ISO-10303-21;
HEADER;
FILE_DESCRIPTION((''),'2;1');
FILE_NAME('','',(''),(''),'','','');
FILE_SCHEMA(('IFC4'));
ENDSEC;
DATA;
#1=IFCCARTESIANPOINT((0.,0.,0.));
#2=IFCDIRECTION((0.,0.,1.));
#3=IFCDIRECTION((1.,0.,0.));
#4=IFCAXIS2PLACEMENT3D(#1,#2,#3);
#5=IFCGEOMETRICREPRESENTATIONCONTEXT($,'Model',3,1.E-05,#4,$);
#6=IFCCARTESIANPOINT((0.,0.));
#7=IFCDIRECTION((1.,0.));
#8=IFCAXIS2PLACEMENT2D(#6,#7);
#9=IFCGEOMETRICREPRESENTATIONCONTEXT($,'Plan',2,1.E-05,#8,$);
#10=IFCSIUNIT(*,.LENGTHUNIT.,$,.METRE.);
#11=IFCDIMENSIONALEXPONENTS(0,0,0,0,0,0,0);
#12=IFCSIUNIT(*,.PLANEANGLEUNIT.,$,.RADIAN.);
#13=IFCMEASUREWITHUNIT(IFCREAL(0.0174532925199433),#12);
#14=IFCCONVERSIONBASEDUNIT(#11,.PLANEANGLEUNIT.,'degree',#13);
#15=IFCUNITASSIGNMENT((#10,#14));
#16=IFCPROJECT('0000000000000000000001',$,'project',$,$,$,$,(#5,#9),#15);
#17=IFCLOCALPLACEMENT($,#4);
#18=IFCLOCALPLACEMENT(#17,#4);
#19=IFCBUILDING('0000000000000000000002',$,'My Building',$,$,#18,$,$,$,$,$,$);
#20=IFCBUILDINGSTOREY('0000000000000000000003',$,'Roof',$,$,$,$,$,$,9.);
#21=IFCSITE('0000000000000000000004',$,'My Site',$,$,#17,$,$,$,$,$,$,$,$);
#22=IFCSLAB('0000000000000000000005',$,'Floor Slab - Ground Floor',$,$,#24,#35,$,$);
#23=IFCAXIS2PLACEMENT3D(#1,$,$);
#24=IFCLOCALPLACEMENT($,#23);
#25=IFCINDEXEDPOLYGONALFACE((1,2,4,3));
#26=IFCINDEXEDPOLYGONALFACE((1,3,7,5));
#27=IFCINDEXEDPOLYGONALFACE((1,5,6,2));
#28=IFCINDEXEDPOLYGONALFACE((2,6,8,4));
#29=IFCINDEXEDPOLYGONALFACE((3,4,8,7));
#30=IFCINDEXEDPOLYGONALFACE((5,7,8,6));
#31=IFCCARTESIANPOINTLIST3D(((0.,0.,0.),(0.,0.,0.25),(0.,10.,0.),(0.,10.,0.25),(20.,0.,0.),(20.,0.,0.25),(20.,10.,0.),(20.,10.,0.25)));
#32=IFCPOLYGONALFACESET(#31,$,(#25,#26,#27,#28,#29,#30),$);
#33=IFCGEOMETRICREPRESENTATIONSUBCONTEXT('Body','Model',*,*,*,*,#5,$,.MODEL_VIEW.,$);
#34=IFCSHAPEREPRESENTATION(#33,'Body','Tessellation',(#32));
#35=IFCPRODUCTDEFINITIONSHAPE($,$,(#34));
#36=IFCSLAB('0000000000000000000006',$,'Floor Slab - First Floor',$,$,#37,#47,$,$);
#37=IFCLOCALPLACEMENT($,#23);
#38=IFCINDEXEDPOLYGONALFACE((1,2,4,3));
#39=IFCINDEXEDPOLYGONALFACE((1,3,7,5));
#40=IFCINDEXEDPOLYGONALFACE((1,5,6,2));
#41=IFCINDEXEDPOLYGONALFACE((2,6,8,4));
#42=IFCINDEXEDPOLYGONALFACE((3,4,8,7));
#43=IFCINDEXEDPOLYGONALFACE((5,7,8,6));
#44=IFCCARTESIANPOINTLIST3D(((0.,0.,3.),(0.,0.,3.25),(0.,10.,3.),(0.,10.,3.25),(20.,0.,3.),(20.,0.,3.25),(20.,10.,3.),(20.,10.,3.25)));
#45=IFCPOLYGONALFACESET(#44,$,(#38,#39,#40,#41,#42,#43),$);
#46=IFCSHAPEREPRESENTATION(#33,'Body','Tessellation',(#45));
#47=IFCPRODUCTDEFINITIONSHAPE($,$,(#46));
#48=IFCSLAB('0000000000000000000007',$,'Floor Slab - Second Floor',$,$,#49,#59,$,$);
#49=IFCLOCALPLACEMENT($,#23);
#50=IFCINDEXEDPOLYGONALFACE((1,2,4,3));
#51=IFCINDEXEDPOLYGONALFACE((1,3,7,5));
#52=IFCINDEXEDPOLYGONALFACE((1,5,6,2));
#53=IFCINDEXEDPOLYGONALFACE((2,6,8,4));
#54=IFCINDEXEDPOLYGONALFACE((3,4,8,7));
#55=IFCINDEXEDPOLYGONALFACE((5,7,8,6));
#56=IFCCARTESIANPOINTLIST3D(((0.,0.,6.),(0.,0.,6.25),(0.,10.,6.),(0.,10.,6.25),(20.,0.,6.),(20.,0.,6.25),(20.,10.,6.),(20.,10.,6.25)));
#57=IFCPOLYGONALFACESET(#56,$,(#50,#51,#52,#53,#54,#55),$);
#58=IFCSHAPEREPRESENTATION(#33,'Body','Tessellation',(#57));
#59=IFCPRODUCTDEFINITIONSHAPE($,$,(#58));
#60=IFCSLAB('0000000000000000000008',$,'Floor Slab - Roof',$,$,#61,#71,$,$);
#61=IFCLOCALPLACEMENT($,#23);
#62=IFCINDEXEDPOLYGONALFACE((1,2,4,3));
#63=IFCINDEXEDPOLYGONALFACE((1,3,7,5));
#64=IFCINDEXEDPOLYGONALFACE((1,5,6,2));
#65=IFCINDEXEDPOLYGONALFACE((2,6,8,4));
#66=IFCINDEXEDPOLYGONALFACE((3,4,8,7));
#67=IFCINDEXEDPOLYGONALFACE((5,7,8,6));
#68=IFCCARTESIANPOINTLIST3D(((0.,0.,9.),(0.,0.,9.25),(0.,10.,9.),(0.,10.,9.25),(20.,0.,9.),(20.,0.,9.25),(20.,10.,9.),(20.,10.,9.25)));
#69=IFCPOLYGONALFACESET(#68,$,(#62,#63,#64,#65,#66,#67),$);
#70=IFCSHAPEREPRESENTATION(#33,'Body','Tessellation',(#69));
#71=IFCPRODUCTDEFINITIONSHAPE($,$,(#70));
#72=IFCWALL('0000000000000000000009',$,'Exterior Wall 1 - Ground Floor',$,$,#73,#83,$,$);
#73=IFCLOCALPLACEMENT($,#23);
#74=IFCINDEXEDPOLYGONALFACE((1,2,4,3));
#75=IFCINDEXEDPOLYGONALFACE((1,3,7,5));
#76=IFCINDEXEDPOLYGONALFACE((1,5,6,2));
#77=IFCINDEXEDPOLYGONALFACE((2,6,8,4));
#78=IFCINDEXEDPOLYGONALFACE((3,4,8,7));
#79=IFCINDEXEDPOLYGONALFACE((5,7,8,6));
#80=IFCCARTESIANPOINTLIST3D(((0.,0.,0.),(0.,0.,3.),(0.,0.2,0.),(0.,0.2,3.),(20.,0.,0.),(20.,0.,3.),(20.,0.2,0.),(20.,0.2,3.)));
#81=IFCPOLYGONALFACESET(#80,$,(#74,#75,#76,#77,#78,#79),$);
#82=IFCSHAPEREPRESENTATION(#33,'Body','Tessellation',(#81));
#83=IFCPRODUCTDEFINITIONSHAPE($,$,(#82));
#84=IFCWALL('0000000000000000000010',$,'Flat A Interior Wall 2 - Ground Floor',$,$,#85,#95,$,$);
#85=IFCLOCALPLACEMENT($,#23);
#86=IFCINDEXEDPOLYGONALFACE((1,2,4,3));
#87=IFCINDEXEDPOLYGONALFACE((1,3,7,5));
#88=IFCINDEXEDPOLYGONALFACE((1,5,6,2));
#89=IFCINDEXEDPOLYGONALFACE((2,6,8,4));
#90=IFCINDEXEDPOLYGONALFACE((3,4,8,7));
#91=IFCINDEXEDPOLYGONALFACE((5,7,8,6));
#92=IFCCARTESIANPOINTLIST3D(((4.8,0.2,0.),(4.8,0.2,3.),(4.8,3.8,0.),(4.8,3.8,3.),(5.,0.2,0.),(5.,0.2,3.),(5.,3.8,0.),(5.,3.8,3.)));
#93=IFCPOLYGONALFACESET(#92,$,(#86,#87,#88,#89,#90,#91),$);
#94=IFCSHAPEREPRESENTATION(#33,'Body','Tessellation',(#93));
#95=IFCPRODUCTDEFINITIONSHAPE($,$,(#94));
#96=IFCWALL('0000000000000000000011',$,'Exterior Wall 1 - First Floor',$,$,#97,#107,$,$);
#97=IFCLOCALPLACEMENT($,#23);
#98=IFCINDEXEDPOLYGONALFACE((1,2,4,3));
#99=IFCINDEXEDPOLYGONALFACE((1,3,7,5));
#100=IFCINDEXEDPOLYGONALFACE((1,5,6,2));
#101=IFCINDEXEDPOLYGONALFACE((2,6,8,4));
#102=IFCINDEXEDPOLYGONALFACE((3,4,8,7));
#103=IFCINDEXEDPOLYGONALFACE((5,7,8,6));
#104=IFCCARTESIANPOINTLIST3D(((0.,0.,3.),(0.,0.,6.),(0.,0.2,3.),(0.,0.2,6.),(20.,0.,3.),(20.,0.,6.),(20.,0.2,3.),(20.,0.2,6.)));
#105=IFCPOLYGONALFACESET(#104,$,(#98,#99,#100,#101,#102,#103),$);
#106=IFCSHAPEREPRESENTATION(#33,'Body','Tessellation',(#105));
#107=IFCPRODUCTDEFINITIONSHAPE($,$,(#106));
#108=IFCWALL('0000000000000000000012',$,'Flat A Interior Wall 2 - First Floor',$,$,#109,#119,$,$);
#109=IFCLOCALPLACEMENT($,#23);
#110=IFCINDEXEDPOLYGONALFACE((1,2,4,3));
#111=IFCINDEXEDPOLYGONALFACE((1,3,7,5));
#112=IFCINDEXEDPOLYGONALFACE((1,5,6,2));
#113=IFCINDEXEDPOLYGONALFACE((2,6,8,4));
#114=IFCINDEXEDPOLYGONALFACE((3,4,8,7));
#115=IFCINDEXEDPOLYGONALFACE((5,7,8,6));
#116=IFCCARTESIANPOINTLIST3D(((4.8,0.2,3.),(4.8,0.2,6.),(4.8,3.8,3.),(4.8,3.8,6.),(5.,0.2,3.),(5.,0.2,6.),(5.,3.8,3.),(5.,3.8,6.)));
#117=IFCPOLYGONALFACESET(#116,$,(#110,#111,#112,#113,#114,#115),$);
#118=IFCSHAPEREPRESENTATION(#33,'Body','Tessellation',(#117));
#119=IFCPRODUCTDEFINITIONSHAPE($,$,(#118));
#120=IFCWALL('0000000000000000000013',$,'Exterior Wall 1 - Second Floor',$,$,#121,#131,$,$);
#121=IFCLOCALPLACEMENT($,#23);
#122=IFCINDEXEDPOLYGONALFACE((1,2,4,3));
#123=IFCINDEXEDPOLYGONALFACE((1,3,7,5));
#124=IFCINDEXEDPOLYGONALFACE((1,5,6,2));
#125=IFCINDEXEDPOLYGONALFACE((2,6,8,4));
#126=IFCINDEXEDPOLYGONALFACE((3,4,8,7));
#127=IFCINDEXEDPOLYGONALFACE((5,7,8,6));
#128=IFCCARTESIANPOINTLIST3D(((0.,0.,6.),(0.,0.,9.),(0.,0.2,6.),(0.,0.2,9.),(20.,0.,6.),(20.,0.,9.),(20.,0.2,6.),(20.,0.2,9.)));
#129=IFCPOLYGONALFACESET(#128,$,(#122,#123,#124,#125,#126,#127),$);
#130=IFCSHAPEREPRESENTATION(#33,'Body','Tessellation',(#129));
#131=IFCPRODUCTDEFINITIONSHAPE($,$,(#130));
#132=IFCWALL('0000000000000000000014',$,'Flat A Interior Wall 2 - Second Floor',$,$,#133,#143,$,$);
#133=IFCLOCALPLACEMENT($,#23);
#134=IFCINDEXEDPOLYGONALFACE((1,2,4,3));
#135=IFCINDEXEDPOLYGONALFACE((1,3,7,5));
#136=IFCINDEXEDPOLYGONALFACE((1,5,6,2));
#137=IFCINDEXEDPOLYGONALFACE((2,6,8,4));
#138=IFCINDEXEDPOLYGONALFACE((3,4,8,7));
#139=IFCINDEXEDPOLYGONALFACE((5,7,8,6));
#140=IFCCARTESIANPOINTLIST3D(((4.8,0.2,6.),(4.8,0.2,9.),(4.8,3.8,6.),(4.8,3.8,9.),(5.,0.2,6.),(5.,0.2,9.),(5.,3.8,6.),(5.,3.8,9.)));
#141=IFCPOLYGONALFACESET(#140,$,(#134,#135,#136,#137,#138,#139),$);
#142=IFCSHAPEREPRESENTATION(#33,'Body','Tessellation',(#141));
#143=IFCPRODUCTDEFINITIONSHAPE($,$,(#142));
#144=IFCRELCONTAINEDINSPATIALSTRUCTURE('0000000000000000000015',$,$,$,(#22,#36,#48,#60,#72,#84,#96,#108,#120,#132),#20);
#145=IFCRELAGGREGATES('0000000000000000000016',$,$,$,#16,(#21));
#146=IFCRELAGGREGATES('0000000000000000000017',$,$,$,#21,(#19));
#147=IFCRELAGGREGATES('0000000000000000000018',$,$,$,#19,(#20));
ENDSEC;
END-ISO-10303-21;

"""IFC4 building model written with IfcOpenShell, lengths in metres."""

from ifc_helpers import new_model, entity, si_unit, converted_unit, frame, origin_with_axes, origin_2d_with_axis, place, context, subcontext, project, spatial, indexed_curve, outline, extrude, element, save


model = new_model("IFC4")

# Units and contexts
model_context = context("Model", 3, precision=1e-05, world=origin_with_axes())
plan_context = context("Plan", 2, precision=1e-05, world=origin_2d_with_axis())
body_context = subcontext(model_context, "Body", "Model", "MODEL_VIEW")
ifc_project = project(units=[si_unit("LENGTHUNIT", "METRE"), converted_unit("PLANEANGLEUNIT", "degree", entity("IfcReal", 0.0174532925199433), si_unit("PLANEANGLEUNIT", "RADIAN"), dimensions=[0, 0, 0, 0, 0, 0, 0])], contexts=[model_context, plan_context])

# Site, building, storey
site_placement = place(None, origin_with_axes())
site = spatial("IfcSite", under=ifc_project, at=site_placement, Name="My Site")
building_placement = place(site_placement, origin_with_axes())
building = spatial("IfcBuilding", under=site, at=building_placement, Name="My Building")
storey = spatial("IfcBuildingStorey", under=building, Name="Roof", Elevation=9.0)

# Slabs
for number, where, z_axis, x_axis, name in (
    (1, (0.0, 0.0, 0.0), (0.0, 0.0, 1.0), (1.0, 0.0, 0.0), "Floor Slab - Ground Floor"),
    (2, (0.0, 0.0, 3.0), (0.0, 0.0, 1.0), (1.0, 0.0, 0.0), "Floor Slab - First Floor"),
    (3, (0.0, 0.0, 6.0), (0.0, 0.0, 1.0), (1.0, 0.0, 0.0), "Floor Slab - Second Floor"),
    (4, (0.0, 0.0, 9.0), (0.0, 0.0, 1.0), (1.0, 0.0, 0.0), "Floor Slab - Roof"),
):
    element("IfcSlab", number, at=place(None, frame(where, z_axis=z_axis, x_axis=x_axis)), inside=storey, Name=name, context=body_context, shape_type="SweptSolid", body=[
        extrude(outline(indexed_curve([(0.0, 0.0), (20.0, 0.0), (20.0, 10.0), (0.0, 10.0)])), None, (0.0, 0.0, 1.0), 0.25),
    ])

# Walls
wall_1_placement = place(None, origin_with_axes())
element("IfcWall", 5, at=wall_1_placement, inside=storey, Name="Exterior Wall 1 - Ground Floor", context=body_context, shape_type="SweptSolid", body=[
    extrude(outline(indexed_curve([(0.0, 0.0), (0.0, 0.2), (20.0, 0.2), (20.0, 0.0), (0.0, 0.0)], self_intersect=False)), origin_with_axes(), (0.0, 0.0, 1.0), 3.0),
])
wall_2_placement = place(None, frame((5.0, 0.2, 0.0), z_axis=(0.0, 0.0, 1.0), x_axis=(0.0, 1.0, 0.0)))
element("IfcWall", 6, at=wall_2_placement, inside=storey, Name="Flat A Interior Wall 2 - Ground Floor", context=body_context, shape_type="SweptSolid", body=[
    extrude(outline(indexed_curve([(0.0, 0.0), (0.0, 0.2), (3.6, 0.2), (3.6, 0.0), (0.0, 0.0)], self_intersect=False)), origin_with_axes(), (0.0, 0.0, 1.0), 3.0),
])
wall_3_placement = place(None, frame((0.0, 0.0, 3.0), z_axis=(0.0, 0.0, 1.0), x_axis=(1.0, 0.0, 0.0)))
element("IfcWall", 7, at=wall_3_placement, inside=storey, Name="Exterior Wall 1 - First Floor", context=body_context, shape_type="SweptSolid", body=[
    extrude(outline(indexed_curve([(0.0, 0.0), (0.0, 0.2), (20.0, 0.2), (20.0, 0.0), (0.0, 0.0)], self_intersect=False)), origin_with_axes(), (0.0, 0.0, 1.0), 3.0),
])
wall_4_placement = place(None, frame((5.0, 0.2, 3.0), z_axis=(0.0, 0.0, 1.0), x_axis=(0.0, 1.0, 0.0)))
element("IfcWall", 8, at=wall_4_placement, inside=storey, Name="Flat A Interior Wall 2 - First Floor", context=body_context, shape_type="SweptSolid", body=[
    extrude(outline(indexed_curve([(0.0, 0.0), (0.0, 0.2), (3.6, 0.2), (3.6, 0.0), (0.0, 0.0)], self_intersect=False)), origin_with_axes(), (0.0, 0.0, 1.0), 3.0),
])
wall_5_placement = place(None, frame((0.0, 0.0, 6.0), z_axis=(0.0, 0.0, 1.0), x_axis=(1.0, 0.0, 0.0)))
element("IfcWall", 9, at=wall_5_placement, inside=storey, Name="Exterior Wall 1 - Second Floor", context=body_context, shape_type="SweptSolid", body=[
    extrude(outline(indexed_curve([(0.0, 0.0), (0.0, 0.2), (20.0, 0.2), (20.0, 0.0), (0.0, 0.0)], self_intersect=False)), origin_with_axes(), (0.0, 0.0, 1.0), 3.0),
])
wall_6_placement = place(None, frame((5.0, 0.2, 6.0), z_axis=(0.0, 0.0, 1.0), x_axis=(0.0, 1.0, 0.0)))
element("IfcWall", 10, at=wall_6_placement, inside=storey, Name="Flat A Interior Wall 2 - Second Floor", context=body_context, shape_type="SweptSolid", body=[
    extrude(outline(indexed_curve([(0.0, 0.0), (0.0, 0.2), (3.6, 0.2), (3.6, 0.0), (0.0, 0.0)], self_intersect=False)), origin_with_axes(), (0.0, 0.0, 1.0), 3.0),
])

save(model, "model.ifc")
